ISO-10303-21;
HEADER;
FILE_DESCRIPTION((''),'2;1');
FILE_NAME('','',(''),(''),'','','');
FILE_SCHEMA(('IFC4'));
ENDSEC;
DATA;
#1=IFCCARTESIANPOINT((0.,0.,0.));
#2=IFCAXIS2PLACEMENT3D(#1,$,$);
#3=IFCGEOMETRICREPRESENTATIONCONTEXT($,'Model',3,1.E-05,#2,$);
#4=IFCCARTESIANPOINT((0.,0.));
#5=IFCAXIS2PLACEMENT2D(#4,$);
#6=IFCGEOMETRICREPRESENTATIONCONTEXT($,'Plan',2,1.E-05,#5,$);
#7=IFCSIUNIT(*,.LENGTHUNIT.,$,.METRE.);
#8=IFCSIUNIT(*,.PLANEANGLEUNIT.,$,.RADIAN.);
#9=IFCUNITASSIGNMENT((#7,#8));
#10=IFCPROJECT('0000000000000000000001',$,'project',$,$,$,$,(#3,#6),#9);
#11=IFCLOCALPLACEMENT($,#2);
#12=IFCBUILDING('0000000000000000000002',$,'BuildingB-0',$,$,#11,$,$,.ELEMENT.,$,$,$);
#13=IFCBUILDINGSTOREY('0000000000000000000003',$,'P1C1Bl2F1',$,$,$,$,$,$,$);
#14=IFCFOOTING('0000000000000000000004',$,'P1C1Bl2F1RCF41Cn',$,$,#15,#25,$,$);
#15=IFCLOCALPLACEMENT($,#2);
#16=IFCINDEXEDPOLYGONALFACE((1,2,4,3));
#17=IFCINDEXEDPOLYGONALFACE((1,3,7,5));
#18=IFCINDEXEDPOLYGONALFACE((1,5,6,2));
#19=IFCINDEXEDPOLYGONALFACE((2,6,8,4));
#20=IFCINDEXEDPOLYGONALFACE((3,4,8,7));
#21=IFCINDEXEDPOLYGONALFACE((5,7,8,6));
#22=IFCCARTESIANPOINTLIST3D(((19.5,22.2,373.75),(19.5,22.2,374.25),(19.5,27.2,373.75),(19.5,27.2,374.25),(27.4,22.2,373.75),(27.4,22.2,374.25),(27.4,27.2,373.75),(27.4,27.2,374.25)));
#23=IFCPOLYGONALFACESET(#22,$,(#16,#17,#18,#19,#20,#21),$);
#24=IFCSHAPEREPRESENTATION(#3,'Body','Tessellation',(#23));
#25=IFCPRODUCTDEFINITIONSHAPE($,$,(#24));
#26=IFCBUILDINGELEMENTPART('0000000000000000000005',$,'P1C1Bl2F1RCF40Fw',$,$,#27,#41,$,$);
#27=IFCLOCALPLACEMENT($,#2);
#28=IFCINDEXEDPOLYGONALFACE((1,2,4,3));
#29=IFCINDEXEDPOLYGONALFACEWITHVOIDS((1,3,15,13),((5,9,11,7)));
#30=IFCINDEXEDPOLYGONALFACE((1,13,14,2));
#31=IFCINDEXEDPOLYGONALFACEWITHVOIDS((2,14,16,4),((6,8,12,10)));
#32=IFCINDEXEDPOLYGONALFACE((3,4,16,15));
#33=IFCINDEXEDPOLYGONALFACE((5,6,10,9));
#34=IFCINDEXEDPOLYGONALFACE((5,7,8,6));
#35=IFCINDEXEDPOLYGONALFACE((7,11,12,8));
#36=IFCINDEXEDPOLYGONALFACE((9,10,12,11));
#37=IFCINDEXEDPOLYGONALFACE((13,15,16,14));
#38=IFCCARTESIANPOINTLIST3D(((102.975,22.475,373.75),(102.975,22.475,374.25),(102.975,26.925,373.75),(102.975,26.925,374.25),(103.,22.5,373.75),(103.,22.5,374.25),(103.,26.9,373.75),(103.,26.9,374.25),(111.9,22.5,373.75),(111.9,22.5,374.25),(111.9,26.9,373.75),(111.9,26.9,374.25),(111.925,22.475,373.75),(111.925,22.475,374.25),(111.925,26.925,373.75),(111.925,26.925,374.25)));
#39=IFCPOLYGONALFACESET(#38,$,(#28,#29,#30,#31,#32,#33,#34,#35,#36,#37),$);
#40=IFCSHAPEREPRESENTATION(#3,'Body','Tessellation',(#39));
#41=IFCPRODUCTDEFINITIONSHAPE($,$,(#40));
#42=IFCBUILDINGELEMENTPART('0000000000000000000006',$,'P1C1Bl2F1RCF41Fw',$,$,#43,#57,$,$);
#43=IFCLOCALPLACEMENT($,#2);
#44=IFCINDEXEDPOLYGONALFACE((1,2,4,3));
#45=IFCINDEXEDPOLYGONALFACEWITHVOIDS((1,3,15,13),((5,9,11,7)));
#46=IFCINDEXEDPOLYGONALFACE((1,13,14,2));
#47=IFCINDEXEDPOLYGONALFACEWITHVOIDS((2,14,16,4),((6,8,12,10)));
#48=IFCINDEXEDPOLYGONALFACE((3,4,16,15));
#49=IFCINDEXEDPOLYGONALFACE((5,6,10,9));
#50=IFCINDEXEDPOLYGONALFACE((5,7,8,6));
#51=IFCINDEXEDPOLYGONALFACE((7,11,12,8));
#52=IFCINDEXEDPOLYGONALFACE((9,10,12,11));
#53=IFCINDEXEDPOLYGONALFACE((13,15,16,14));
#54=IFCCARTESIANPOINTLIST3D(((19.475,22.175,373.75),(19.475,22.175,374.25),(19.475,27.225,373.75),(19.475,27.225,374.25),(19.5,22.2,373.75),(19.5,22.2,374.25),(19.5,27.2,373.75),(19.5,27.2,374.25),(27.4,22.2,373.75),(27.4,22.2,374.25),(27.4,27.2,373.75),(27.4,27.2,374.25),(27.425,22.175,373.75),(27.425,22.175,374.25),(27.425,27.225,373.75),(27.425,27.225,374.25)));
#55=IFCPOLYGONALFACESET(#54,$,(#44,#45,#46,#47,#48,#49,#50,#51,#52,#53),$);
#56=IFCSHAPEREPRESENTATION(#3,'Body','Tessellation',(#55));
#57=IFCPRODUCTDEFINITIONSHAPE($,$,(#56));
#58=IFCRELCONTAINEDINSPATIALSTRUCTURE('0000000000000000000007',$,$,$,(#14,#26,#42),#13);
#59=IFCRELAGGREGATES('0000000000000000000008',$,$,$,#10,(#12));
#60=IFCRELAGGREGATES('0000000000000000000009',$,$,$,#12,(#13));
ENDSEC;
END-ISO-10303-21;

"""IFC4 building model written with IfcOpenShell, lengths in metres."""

from ifc_helpers import new_model, si_unit, origin, origin_2d, place, context, project, spatial, polyline, outline, extrude, element, save


model = new_model("IFC4")

# Units and contexts
model_context = context("Model", 3, precision=1e-05, world=origin())
plan_context = context("Plan", 2, precision=1e-05, world=origin_2d())
ifc_project = project(units=[si_unit("LENGTHUNIT", "METRE"), si_unit("PLANEANGLEUNIT", "RADIAN")], contexts=[model_context, plan_context])

# Building, storey
building_placement = place(None, origin())
building = spatial("IfcBuilding", under=ifc_project, at=building_placement, Name="BuildingB-0", CompositionType="ELEMENT")
storey = spatial("IfcBuildingStorey", under=building, Name="P1C1Bl2F1")

# Footing
element("IfcFooting", 1, inside=storey, Name="P1C1Bl2F1RCF41Cn", context=model_context, shape_type="SweptSolid", body=[
    extrude(outline(polyline([(27.4, 27.2, 373.75), (19.5, 27.2, 373.75), (19.5, 22.2, 373.75), (27.4, 22.2, 373.75), (27.4, 27.2, 373.75)])), None, (0.0, 0.0, 1.0), 0.5),
])

# Building element part, opening
building_element_part_1 = element("IfcBuildingElementPart", 2, inside=storey, Name="P1C1Bl2F1RCF40Fw", context=model_context, shape_type="SweptSolid", body=[
    extrude(outline(polyline([(111.925, 26.925, 373.75), (102.975, 26.925, 373.75), (102.975, 22.475, 373.75), (111.925, 22.475, 373.75), (111.925, 26.925, 373.75)])), None, (0.0, 0.0, 1.0), 0.5),
])
element("IfcOpeningElement", 3, inside=storey, cuts=building_element_part_1, context=model_context, shape_type="SweptSolid", body=[
    extrude(outline(polyline([(111.9, 26.9, 373.75), (103.0, 26.9, 373.75), (103.0, 22.5, 373.75), (111.9, 22.5, 373.75), (111.9, 26.9, 373.75)])), None, (0.0, 0.0, 1.0), 0.5),
])

# Building element part, opening
building_element_part_2 = element("IfcBuildingElementPart", 4, inside=storey, Name="P1C1Bl2F1RCF41Fw", context=model_context, shape_type="SweptSolid", body=[
    extrude(outline(polyline([(27.425, 27.225, 373.75), (19.475, 27.225, 373.75), (19.475, 22.175, 373.75), (27.425, 22.175, 373.75), (27.425, 27.225, 373.75)])), None, (0.0, 0.0, 1.0), 0.5),
])
element("IfcOpeningElement", 5, inside=storey, cuts=building_element_part_2, context=model_context, shape_type="SweptSolid", body=[
    extrude(outline(polyline([(27.4, 27.2, 373.75), (19.5, 27.2, 373.75), (19.5, 22.2, 373.75), (27.4, 22.2, 373.75), (27.4, 27.2, 373.75)])), None, (0.0, 0.0, 1.0), 0.5),
])

save(model, "model.ifc")
